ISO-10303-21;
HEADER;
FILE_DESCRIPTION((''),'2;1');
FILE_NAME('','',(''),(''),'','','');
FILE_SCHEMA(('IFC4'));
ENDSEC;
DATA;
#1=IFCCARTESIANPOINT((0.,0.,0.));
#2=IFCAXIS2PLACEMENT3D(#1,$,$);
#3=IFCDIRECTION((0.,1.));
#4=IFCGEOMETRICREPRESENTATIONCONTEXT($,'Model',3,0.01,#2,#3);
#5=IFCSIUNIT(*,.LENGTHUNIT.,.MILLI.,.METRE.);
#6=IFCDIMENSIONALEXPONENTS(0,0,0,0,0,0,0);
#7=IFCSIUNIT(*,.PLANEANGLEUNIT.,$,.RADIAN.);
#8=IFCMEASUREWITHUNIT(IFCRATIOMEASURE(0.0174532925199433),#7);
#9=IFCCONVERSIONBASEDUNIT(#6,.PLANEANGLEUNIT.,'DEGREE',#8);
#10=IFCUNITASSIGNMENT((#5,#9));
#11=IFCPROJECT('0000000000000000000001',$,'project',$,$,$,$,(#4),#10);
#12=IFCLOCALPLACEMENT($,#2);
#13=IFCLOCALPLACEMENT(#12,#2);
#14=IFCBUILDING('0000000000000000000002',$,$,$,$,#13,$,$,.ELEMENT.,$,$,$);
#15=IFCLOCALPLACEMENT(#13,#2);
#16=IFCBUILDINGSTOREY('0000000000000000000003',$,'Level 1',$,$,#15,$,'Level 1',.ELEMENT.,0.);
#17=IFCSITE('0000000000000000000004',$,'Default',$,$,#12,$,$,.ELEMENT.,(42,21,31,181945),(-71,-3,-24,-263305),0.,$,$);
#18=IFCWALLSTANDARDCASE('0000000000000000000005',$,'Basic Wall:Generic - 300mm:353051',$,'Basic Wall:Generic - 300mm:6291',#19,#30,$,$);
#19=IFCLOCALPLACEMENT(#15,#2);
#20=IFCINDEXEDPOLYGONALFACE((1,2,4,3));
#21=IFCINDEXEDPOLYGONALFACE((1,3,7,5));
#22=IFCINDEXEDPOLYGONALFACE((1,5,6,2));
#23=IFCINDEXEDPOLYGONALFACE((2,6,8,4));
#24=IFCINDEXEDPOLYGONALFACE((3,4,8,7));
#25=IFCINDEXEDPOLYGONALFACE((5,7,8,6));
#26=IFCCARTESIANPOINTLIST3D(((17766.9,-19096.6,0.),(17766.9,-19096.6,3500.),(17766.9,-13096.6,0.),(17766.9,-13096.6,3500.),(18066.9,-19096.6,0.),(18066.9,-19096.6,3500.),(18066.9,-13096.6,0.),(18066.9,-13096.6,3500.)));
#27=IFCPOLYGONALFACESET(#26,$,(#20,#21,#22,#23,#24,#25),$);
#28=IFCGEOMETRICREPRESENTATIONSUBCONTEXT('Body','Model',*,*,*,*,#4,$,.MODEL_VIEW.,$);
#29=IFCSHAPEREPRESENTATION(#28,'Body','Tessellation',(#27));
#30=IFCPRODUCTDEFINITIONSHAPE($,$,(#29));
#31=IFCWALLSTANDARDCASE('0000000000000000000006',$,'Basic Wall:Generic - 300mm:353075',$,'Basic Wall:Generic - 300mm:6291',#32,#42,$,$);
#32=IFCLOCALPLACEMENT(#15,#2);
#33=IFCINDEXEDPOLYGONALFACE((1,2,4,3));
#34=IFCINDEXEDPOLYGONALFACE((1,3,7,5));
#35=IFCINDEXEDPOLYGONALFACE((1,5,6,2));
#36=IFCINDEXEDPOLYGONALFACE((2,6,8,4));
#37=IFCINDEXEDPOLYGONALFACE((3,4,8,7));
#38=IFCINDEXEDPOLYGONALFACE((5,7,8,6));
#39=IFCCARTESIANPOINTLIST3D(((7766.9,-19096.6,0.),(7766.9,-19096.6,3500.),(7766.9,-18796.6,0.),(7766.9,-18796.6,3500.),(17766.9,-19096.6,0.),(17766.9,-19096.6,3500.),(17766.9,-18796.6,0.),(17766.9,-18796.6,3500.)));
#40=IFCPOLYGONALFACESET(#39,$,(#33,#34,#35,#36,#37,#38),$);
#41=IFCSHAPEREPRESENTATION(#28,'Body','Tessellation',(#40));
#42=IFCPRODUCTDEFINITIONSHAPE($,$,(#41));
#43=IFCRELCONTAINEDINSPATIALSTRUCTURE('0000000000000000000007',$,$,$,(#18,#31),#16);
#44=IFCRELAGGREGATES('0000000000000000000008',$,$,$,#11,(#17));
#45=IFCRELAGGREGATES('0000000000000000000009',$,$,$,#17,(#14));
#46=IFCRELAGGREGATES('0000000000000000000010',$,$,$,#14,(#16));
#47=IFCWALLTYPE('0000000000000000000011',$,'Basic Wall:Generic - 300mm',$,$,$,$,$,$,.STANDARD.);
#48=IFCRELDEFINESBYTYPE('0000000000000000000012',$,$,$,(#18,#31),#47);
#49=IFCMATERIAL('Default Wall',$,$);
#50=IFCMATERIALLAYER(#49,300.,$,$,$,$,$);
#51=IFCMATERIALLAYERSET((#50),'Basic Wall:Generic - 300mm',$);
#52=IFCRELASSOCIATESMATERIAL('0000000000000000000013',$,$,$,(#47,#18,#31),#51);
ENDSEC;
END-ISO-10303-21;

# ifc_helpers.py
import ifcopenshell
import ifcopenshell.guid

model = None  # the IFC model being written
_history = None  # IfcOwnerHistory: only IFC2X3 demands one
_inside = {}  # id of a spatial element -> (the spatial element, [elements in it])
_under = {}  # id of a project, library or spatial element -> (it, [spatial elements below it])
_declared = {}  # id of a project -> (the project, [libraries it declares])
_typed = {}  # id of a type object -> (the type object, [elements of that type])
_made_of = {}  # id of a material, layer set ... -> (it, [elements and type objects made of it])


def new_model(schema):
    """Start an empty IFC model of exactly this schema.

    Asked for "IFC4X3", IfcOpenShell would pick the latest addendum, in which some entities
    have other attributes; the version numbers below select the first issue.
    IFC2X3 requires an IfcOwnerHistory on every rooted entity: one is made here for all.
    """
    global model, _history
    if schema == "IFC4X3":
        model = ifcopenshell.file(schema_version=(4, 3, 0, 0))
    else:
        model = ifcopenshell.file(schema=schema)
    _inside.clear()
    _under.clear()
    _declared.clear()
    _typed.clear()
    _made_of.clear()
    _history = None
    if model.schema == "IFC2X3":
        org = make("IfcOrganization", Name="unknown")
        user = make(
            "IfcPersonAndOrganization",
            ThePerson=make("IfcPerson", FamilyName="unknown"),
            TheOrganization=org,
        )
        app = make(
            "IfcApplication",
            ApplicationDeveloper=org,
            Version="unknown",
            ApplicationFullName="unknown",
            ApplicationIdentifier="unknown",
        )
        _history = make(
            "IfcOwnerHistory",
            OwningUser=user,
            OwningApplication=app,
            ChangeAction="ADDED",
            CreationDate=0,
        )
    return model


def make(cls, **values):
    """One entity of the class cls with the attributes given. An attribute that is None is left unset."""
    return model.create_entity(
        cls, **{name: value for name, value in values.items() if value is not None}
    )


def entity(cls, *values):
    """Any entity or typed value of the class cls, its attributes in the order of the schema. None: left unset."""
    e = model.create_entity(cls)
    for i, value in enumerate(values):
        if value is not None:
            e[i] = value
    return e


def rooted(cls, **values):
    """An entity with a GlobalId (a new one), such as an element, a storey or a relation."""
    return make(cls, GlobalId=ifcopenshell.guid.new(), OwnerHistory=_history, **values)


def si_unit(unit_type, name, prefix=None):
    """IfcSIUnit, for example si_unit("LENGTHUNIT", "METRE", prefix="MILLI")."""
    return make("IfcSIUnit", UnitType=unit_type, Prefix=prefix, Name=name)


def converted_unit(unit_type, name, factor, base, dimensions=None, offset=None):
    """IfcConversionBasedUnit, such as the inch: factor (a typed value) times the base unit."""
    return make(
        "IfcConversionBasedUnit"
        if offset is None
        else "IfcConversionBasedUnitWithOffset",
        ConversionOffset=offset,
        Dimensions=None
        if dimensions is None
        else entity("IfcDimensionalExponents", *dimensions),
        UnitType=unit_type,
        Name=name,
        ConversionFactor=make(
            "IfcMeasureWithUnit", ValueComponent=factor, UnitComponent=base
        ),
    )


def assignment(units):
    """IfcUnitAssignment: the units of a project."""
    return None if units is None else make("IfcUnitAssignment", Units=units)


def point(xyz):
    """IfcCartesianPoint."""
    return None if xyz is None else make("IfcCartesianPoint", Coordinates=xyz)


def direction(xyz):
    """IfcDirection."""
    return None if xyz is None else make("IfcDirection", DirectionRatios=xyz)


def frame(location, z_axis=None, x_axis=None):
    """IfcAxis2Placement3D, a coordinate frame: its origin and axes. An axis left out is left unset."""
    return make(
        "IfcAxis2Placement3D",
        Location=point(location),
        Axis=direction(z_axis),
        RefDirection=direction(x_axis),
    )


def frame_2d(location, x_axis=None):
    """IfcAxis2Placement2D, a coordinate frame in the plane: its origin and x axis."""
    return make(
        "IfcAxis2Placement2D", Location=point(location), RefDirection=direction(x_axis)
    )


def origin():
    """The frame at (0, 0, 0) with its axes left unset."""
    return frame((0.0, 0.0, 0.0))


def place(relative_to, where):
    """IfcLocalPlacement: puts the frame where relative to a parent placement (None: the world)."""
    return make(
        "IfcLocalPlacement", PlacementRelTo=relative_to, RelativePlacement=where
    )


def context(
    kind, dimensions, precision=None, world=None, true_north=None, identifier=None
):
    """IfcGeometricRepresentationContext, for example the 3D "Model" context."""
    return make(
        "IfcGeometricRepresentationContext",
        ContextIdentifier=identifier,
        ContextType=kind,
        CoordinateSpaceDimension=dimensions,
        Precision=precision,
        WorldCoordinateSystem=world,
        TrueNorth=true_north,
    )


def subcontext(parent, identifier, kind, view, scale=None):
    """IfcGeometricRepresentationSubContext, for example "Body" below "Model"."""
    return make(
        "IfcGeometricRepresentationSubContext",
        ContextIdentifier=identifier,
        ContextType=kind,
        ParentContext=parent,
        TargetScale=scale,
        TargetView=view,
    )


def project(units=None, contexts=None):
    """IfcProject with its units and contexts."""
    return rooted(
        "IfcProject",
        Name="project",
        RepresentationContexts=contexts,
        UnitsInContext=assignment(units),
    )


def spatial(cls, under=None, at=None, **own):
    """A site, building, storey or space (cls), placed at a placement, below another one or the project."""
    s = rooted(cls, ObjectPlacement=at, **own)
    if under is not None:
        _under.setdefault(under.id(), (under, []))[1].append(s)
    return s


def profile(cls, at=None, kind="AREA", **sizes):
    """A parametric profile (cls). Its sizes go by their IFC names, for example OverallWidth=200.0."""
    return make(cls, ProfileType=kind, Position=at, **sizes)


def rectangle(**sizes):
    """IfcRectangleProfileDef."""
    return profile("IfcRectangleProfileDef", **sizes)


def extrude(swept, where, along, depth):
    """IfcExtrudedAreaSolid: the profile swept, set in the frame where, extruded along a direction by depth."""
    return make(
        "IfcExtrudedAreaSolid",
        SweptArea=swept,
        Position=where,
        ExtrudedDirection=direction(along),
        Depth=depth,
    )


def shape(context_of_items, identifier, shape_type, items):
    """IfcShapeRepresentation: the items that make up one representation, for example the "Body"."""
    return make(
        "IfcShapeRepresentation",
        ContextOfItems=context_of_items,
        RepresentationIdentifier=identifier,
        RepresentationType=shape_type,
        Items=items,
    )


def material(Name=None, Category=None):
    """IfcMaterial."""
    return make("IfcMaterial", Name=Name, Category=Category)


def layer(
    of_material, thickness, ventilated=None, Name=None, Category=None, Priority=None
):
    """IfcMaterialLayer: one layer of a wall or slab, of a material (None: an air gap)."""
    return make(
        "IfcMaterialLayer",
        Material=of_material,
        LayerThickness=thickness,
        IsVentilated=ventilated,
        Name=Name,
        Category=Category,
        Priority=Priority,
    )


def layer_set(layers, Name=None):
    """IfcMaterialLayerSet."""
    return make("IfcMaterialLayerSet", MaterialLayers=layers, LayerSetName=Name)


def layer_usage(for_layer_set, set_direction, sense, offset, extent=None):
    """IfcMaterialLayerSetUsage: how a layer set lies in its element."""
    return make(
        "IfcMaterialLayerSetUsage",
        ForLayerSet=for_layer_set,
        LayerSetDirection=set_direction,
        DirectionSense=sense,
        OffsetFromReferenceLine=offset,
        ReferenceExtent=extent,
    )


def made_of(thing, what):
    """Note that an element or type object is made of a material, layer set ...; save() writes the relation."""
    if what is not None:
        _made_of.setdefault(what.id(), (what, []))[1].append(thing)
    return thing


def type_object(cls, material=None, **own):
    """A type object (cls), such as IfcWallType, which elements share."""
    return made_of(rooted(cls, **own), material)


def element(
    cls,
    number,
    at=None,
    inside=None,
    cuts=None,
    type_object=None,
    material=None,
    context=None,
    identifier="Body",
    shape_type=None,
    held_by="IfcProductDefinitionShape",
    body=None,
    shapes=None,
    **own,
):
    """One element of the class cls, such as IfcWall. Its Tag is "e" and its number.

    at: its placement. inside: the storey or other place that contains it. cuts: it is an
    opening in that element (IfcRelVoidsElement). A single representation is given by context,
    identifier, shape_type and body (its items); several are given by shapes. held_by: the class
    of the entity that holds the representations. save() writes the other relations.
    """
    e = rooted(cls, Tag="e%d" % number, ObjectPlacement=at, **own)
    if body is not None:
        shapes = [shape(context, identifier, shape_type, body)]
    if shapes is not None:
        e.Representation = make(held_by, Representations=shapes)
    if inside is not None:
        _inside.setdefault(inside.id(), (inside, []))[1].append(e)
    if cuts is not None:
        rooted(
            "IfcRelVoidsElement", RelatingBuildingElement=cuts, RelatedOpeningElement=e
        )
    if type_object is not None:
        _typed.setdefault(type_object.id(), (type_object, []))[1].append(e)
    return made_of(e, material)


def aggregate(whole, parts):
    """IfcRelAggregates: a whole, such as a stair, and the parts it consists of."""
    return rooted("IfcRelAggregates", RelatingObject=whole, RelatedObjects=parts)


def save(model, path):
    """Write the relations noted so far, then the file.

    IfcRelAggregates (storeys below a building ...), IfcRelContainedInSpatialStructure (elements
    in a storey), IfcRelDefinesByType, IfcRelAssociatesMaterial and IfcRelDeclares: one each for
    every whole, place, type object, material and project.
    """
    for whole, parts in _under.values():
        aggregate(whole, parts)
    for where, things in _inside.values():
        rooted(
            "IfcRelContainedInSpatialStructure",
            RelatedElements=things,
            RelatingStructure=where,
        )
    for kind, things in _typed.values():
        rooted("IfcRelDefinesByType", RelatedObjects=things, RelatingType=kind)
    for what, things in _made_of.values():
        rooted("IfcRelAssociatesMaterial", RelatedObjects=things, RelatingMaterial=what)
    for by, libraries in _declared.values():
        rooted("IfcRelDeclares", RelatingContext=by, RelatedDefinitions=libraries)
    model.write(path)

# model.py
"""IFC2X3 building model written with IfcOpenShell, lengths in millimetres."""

from ifc_helpers import new_model, entity, si_unit, converted_unit, direction, frame, frame_2d, origin, place, context, subcontext, project, spatial, rectangle, extrude, material, layer, layer_set, layer_usage, type_object, element, save


model = new_model("IFC2X3")

# Units and contexts
model_context = context("Model", 3, precision=0.01, world=origin(), true_north=direction((0.0, 1.0)))
body_context = subcontext(model_context, "Body", "Model", "MODEL_VIEW")
ifc_project = project(units=[si_unit("LENGTHUNIT", "METRE", prefix="MILLI"), converted_unit("PLANEANGLEUNIT", "DEGREE", entity("IfcRatioMeasure", 0.0174532925199433), si_unit("PLANEANGLEUNIT", "RADIAN"), dimensions=[0, 0, 0, 0, 0, 0, 0])], contexts=[model_context])

# Site, building, storey
site_placement = place(None, origin())
site = spatial("IfcSite", under=ifc_project, at=site_placement, Name="Default", CompositionType="ELEMENT", RefLatitude=(42, 21, 31, 181945), RefLongitude=(-71, -3, -24, -263305), RefElevation=0.0)
building_placement = place(site_placement, origin())
building = spatial("IfcBuilding", under=site, at=building_placement, CompositionType="ELEMENT")
storey_placement = place(building_placement, origin())
storey = spatial("IfcBuildingStorey", under=building, at=storey_placement, Name="Level 1", LongName="Level 1", CompositionType="ELEMENT", Elevation=0.0)

# Walls
ifc_material_1 = material(Name="Default Wall")
ifc_layer = layer(ifc_material_1, 300.0)
ifc_layer_set = layer_set([ifc_layer], Name="Basic Wall:Generic - 300mm")
ifc_layer_usage_1 = layer_usage(ifc_layer_set, "AXIS2", "NEGATIVE", 150.0)
wall_type = type_object("IfcWallType", Name="Basic Wall:Generic - 300mm", PredefinedType="STANDARD", material=ifc_layer_set)
wall_1_placement = place(storey_placement, frame((17916.9, -13096.6, 0.0), z_axis=(0.0, 0.0, 1.0), x_axis=(0.0, -1.0, 0.0)))
element("IfcWallStandardCase", 1, at=wall_1_placement, inside=storey, type_object=wall_type, material=ifc_layer_usage_1, Name="Basic Wall:Generic - 300mm:353051", ObjectType="Basic Wall:Generic - 300mm:6291", context=body_context, shape_type="SweptSolid", body=[
    extrude(rectangle(XDim=6000.0, YDim=300.0, at=frame_2d((3000.0, 0.0), x_axis=(-1.0, 0.0))), origin(), (0.0, 0.0, 1.0), 3500.0),
])
ifc_layer_usage_2 = layer_usage(ifc_layer_set, "AXIS2", "NEGATIVE", 150.0)
wall_2_placement = place(storey_placement, frame((17766.9, -18946.6, 0.0), z_axis=(0.0, 0.0, 1.0), x_axis=(-1.0, 0.0, 0.0)))
element("IfcWallStandardCase", 2, at=wall_2_placement, inside=storey, type_object=wall_type, material=ifc_layer_usage_2, Name="Basic Wall:Generic - 300mm:353075", ObjectType="Basic Wall:Generic - 300mm:6291", context=body_context, shape_type="SweptSolid", body=[
    extrude(rectangle(XDim=10000.0, YDim=300.0, at=frame_2d((5000.0, 0.0), x_axis=(-1.0, 0.0))), origin(), (0.0, 0.0, 1.0), 3500.0),
])

save(model, "model.ifc")
